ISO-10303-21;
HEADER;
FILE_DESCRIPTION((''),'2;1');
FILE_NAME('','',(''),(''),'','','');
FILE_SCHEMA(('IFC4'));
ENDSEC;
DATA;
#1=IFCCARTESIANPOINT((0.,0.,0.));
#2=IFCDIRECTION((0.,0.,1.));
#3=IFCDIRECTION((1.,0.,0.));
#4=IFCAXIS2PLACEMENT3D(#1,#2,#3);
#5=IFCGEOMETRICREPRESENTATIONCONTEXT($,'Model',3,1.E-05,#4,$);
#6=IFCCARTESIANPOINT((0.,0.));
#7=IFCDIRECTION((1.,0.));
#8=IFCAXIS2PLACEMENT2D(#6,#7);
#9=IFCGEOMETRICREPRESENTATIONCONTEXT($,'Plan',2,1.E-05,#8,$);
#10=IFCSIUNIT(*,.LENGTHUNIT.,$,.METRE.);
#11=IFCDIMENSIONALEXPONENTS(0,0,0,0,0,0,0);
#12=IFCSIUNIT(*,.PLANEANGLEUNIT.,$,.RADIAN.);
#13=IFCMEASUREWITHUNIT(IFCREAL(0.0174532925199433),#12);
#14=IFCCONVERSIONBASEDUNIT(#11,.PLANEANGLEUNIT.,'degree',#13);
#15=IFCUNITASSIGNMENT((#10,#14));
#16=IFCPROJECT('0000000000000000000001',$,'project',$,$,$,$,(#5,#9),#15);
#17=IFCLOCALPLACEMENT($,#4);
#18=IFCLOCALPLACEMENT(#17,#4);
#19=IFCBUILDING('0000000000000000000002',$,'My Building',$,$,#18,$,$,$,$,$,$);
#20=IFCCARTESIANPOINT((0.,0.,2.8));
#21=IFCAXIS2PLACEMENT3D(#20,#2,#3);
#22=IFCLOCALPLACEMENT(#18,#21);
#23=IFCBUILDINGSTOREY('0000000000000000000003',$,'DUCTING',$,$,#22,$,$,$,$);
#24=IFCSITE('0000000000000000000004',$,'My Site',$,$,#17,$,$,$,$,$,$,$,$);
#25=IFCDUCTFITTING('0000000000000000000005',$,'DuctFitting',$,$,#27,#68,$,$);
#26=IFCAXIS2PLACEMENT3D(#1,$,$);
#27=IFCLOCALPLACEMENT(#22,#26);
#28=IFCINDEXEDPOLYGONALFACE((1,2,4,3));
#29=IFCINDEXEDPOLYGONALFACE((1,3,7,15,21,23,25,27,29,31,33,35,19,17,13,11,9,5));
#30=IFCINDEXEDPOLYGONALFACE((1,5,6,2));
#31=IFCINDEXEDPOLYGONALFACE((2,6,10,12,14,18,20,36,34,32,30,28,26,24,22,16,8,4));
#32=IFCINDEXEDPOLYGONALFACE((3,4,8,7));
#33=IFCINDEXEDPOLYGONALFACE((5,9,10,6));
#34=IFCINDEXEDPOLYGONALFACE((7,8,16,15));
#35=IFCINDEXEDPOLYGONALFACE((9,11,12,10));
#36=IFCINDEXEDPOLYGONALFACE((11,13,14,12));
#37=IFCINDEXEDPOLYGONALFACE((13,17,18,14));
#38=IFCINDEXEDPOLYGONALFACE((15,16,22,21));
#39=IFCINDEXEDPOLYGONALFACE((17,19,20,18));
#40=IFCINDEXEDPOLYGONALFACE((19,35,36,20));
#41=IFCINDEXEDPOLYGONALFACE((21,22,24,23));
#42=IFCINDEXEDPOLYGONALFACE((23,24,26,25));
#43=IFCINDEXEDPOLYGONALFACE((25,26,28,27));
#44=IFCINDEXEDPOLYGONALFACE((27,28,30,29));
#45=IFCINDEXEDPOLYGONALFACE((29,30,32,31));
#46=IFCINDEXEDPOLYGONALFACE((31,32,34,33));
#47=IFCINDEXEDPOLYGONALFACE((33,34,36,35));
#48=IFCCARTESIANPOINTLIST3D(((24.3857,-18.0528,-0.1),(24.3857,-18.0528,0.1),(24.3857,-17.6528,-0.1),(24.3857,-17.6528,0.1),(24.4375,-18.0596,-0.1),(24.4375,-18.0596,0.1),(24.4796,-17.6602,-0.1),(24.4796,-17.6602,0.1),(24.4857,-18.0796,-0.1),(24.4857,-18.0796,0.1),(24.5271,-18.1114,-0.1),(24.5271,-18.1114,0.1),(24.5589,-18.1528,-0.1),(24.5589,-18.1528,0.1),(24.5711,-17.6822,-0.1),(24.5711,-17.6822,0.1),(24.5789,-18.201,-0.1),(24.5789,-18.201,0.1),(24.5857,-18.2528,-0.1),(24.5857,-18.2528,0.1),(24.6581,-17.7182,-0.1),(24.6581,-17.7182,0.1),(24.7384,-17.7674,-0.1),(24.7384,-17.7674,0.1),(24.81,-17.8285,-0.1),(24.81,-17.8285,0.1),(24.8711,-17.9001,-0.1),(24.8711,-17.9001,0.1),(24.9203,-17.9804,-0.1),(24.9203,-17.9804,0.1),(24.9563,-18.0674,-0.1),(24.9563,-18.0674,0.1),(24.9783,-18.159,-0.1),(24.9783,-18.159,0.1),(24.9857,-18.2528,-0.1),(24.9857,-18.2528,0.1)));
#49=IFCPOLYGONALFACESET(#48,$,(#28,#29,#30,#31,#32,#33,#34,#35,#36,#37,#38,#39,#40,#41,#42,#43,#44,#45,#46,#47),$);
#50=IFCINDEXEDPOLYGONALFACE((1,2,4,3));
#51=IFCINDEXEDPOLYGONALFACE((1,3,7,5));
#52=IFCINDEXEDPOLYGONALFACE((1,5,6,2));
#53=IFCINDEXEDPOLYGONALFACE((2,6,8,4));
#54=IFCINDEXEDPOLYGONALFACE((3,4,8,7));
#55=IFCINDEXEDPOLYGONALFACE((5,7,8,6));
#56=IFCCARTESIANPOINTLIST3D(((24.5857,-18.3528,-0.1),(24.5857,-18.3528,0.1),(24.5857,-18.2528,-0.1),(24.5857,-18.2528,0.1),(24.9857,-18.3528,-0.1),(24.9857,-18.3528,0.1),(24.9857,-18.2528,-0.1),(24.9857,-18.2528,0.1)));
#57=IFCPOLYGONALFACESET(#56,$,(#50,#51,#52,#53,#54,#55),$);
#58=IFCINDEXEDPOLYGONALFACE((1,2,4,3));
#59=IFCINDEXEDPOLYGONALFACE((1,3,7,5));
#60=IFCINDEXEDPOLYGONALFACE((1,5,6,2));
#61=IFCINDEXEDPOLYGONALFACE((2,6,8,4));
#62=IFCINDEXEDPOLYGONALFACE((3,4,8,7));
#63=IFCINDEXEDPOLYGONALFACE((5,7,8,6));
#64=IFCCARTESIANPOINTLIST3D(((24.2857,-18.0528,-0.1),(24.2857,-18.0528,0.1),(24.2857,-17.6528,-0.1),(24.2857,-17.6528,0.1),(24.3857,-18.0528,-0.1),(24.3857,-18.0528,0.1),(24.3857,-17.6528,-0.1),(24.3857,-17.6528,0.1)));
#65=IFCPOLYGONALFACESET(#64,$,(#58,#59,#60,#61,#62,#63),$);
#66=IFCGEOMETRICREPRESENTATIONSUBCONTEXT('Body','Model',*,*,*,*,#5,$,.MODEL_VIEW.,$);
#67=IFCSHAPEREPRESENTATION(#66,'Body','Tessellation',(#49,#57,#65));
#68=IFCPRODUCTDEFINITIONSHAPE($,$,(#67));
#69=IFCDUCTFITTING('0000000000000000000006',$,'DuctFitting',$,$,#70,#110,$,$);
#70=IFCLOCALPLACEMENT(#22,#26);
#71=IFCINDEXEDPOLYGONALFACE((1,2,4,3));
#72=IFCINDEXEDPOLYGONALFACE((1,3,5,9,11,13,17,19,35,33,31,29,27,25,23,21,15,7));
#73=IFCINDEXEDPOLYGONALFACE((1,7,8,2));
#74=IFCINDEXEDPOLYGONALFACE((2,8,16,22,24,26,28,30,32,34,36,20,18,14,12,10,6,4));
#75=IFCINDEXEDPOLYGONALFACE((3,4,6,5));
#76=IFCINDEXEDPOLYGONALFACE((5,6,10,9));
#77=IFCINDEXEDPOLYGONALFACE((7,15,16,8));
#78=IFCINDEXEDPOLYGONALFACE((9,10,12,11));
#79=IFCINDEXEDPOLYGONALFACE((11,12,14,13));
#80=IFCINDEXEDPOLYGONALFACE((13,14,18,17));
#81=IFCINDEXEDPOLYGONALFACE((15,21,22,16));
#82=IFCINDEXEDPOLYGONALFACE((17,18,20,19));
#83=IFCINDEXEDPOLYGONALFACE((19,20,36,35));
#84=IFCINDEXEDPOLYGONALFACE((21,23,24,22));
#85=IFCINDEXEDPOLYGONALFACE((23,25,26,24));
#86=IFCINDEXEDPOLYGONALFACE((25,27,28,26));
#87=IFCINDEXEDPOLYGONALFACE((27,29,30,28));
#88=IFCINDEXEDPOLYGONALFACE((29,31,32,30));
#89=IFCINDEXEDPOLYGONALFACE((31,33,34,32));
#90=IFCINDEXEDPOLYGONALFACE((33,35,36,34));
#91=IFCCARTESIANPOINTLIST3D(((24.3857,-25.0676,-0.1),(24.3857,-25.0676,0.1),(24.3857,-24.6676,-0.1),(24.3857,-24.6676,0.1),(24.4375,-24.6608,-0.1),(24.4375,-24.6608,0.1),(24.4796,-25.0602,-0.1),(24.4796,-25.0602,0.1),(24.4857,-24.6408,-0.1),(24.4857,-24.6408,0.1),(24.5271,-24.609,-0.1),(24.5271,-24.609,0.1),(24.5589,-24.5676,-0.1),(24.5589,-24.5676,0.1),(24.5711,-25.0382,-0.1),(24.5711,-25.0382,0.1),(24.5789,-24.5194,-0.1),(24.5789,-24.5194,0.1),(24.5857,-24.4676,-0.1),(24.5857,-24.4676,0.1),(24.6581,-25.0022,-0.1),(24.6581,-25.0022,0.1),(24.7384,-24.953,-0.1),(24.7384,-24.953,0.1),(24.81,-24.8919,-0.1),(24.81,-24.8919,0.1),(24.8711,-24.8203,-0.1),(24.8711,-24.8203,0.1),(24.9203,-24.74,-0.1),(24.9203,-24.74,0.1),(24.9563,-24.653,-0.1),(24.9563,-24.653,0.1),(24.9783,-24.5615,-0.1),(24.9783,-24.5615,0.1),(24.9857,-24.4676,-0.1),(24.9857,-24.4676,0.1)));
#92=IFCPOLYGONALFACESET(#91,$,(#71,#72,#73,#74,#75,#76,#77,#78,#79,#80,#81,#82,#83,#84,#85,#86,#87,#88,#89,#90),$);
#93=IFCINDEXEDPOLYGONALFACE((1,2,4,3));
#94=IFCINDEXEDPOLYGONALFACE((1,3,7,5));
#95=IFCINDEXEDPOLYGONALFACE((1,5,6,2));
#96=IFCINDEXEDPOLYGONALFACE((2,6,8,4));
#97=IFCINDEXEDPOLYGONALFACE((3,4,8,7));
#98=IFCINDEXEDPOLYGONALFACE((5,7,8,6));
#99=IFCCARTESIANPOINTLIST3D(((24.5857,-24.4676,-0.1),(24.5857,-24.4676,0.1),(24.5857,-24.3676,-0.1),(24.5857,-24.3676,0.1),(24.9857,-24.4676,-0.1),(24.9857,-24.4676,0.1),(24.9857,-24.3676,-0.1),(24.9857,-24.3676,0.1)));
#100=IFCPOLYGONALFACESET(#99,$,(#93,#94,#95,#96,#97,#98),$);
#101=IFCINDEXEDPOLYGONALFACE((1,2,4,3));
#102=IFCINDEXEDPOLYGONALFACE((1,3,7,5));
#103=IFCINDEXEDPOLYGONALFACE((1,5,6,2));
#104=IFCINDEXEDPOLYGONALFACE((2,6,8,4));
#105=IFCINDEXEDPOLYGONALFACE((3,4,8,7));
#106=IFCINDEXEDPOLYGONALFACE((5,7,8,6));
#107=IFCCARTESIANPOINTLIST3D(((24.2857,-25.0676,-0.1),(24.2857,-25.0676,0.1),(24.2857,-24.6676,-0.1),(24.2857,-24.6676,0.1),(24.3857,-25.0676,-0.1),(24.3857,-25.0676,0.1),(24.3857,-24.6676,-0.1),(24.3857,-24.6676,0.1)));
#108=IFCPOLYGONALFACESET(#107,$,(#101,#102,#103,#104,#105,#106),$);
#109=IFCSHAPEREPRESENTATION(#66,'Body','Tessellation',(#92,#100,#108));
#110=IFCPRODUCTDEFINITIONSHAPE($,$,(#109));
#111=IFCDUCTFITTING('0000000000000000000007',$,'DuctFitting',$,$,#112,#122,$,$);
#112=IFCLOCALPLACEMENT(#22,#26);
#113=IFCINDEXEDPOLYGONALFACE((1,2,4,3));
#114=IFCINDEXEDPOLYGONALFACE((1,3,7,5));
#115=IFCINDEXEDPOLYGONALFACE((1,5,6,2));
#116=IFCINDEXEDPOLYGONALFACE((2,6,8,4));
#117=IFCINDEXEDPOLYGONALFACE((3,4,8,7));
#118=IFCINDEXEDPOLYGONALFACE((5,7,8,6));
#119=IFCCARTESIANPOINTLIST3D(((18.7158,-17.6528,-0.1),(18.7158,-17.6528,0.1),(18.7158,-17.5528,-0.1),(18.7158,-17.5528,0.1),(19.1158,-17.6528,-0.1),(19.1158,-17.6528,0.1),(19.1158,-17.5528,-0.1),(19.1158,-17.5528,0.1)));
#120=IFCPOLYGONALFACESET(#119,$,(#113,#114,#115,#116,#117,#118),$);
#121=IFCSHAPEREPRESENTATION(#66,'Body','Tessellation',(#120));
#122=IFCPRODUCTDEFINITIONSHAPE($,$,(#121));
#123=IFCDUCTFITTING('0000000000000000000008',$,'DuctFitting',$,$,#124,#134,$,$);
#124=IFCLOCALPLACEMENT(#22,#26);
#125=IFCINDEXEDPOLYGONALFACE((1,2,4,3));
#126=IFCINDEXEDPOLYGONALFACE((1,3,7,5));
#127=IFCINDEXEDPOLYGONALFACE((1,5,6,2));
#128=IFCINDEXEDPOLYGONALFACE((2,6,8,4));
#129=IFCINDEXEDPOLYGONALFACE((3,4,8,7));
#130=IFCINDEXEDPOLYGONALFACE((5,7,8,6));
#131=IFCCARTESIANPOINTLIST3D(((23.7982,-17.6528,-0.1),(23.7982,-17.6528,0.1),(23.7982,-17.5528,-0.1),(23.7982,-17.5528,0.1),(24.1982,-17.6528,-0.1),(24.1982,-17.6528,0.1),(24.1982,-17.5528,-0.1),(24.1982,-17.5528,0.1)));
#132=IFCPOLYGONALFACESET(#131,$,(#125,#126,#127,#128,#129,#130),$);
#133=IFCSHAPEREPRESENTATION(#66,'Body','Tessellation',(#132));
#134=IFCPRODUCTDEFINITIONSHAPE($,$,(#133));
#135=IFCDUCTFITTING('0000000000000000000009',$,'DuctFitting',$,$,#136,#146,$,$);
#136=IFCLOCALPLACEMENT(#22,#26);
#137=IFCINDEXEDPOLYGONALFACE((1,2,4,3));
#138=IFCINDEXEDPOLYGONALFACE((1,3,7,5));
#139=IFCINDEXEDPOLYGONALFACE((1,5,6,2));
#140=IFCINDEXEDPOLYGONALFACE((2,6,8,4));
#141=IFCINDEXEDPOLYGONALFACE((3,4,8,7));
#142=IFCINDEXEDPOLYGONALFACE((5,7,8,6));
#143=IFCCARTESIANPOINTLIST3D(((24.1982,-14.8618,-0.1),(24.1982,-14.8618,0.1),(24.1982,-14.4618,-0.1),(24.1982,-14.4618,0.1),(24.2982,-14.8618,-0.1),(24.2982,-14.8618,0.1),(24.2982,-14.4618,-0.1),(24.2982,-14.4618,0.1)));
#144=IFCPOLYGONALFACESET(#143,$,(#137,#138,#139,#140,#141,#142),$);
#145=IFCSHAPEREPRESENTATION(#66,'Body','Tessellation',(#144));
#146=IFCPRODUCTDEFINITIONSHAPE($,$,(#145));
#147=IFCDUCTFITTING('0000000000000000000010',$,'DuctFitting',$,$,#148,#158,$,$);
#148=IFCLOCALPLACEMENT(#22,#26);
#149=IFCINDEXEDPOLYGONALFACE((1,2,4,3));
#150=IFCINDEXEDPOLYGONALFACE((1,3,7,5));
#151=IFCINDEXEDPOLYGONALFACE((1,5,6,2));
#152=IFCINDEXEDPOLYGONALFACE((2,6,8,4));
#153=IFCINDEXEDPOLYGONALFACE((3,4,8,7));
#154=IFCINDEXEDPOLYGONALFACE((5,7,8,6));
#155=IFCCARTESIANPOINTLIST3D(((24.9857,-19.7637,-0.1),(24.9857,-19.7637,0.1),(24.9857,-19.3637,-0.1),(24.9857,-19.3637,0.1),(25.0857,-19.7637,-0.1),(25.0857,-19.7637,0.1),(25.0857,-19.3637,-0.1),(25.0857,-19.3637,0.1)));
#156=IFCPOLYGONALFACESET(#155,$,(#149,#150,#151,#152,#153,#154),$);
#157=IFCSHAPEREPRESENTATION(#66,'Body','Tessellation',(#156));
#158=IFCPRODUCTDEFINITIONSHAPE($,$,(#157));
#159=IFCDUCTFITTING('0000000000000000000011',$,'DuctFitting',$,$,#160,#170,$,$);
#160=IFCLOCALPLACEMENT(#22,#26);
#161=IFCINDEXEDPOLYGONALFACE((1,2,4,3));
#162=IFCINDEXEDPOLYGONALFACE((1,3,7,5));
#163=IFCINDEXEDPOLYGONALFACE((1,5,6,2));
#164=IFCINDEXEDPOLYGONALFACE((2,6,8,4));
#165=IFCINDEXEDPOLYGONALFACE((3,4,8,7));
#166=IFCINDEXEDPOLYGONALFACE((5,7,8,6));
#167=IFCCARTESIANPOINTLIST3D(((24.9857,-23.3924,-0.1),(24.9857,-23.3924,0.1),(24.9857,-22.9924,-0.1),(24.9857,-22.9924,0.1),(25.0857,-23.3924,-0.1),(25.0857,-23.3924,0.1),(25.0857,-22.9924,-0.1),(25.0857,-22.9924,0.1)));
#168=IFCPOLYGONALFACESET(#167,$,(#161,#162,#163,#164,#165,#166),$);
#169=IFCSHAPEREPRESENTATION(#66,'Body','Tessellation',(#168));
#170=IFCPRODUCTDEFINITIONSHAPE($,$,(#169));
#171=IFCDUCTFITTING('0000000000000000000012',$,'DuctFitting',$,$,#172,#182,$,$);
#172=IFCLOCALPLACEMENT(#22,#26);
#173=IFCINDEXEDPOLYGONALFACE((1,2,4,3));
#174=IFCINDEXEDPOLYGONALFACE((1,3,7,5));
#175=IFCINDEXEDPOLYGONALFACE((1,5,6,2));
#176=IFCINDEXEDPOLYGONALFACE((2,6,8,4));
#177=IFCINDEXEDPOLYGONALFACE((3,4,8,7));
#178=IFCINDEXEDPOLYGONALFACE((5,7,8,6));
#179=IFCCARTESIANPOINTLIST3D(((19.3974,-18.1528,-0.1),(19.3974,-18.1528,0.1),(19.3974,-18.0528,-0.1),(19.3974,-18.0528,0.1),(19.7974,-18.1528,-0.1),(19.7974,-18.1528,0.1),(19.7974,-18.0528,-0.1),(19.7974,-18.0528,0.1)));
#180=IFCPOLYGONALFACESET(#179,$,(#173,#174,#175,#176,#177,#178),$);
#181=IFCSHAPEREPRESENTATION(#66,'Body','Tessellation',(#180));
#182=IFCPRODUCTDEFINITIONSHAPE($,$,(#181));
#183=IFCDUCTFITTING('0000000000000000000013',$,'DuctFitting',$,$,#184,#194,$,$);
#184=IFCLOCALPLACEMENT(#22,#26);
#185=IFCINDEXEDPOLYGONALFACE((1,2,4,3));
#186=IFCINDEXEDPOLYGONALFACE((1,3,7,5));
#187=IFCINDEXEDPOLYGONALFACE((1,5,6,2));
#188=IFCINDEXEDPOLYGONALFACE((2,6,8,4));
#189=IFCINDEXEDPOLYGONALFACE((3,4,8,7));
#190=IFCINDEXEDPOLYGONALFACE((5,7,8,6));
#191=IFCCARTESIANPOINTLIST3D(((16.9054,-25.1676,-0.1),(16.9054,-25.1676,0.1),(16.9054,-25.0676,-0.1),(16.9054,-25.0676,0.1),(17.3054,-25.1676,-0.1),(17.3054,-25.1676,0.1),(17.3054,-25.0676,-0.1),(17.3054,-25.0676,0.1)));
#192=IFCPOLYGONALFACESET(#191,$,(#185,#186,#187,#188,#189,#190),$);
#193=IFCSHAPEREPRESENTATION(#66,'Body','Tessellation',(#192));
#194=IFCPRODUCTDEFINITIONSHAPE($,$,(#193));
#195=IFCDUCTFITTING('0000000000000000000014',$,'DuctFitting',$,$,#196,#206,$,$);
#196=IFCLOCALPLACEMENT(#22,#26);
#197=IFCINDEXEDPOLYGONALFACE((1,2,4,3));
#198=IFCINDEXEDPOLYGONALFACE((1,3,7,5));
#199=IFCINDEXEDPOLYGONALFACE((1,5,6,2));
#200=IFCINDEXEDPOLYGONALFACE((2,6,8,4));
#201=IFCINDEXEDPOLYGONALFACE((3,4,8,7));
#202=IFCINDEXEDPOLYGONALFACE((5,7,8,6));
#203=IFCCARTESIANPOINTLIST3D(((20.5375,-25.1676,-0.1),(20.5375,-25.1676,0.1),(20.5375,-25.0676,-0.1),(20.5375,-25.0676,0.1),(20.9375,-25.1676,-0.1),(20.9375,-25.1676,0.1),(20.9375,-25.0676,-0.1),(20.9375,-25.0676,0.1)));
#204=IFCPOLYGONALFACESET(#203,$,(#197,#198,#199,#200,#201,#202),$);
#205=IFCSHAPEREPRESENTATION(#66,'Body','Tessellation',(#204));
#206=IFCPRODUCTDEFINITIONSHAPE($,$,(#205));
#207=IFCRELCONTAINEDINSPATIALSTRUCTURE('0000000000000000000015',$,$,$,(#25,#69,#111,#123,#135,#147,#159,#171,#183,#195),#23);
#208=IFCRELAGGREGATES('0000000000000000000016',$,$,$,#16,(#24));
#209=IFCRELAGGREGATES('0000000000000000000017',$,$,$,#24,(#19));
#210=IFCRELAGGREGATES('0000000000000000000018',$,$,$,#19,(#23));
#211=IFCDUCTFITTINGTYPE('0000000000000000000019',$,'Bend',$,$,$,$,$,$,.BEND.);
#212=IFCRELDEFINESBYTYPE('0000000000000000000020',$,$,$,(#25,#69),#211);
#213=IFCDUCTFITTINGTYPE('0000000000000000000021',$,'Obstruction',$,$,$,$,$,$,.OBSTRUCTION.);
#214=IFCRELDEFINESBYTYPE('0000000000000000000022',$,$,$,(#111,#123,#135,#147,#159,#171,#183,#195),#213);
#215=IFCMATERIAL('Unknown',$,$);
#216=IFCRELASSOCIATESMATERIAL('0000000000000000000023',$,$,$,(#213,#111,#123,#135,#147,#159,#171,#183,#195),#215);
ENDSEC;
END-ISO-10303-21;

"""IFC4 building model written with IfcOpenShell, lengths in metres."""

from ifc_helpers import new_model, entity, si_unit, converted_unit, frame, origin_with_axes, origin_2d_with_axis, place, context, subcontext, project, spatial, line, arc, indexed_curve, rectangle, outline, extrude, source, transform, mapped, material, material_profile, profile_set, profile_usage, type_object, type_shapes, element, save


model = new_model("IFC4")

# Units and contexts
model_context = context("Model", 3, precision=1e-05, world=origin_with_axes())
plan_context = context("Plan", 2, precision=1e-05, world=origin_2d_with_axis())
body_context = subcontext(model_context, "Body", "Model", "MODEL_VIEW")
ifc_project = project(units=[si_unit("LENGTHUNIT", "METRE"), converted_unit("PLANEANGLEUNIT", "degree", entity("IfcReal", 0.0174532925199433), si_unit("PLANEANGLEUNIT", "RADIAN"), dimensions=[0, 0, 0, 0, 0, 0, 0])], contexts=[model_context, plan_context])

# Site, building, storey
site_placement = place(None, origin_with_axes())
site = spatial("IfcSite", under=ifc_project, at=site_placement, Name="My Site")
building_placement = place(site_placement, origin_with_axes())
building = spatial("IfcBuilding", under=site, at=building_placement, Name="My Building")
storey_placement = place(building_placement, frame((0.0, 0.0, 2.8), z_axis=(0.0, 0.0, 1.0), x_axis=(1.0, 0.0, 0.0)))
storey = spatial("IfcBuildingStorey", under=building, at=storey_placement, Name="DUCTING")

# Shared definitions
ifc_material = material(Name="Unknown")

# Duct fittings
duct_fitting_type_1 = type_object("IfcDuctFittingType", Name="Bend", PredefinedType="BEND")
shared_shape = source(origin_with_axes(), body_context, "Body", "SweptSolid", [
    extrude(outline(indexed_curve([(-0.2, 0.0), (-0.2586, -0.1414), (-0.4, -0.2), (-0.4, -0.6), (0.0243, -0.4243), (0.2, 0.0)], segments=[arc(1, 2, 3), line(3, 4), arc(4, 5, 6), line(6, 1)])), frame((0.0, -0.1, -0.1), z_axis=(0.0, -1.0, 0.0), x_axis=(1.0, 0.0, 0.0)), (0.0, 0.0, -1.0), 0.2),
    extrude(rectangle(XDim=0.4, YDim=0.2), origin_with_axes(), (0.0, 0.0, -1.0), 0.1),
    extrude(rectangle(XDim=0.4, YDim=0.2), frame((-0.4, 0.0, -0.5), z_axis=(-1.0, 0.0, -0.000001), x_axis=(0.000001, 0.0, -1.0)), (0.0, 0.0, 1.0), 0.1),
])
type_shapes(duct_fitting_type_1, [shared_shape])
for number, where, z_axis, x_axis, name in (
    (1, (24.7857, -18.3528, 0.0), (0.0, -1.0, 0.0), (1.0, 0.0, 0.0), "DuctFitting"),
    (2, (24.7857, -24.3676, 0.0), (0.0, 1.0, 0.0), (1.0, 0.0, 0.0), "DuctFitting"),
):
    element("IfcDuctFitting", number, at=place(storey_placement, frame(where, z_axis=z_axis, x_axis=x_axis)), inside=storey, type_object=duct_fitting_type_1, Name=name, context=body_context, shape_type="MappedRepresentation", body=[
        mapped(shared_shape, transform((0.0, 0.0, 0.0), x_axis=(1.0, 0.0, 0.0), y_axis=(0.0, 1.0, 0.0), z_axis=(0.0, 0.0, 1.0), scale=1.0)),
    ])
ifc_material_profile_1 = material_profile(ifc_material, rectangle(XDim=0.4, YDim=0.2))
ifc_profile_set_1 = profile_set([ifc_material_profile_1])
ifc_profile_usage_1 = profile_usage(ifc_profile_set_1, cardinal=5)
duct_fitting_type_2 = type_object("IfcDuctFittingType", Name="Obstruction", PredefinedType="OBSTRUCTION", material=ifc_profile_set_1)
duct_fitting_1_placement = place(storey_placement, frame((18.9158, -17.6528, 0.0), z_axis=(0.0, 1.0, 0.0), x_axis=(-1.0, 0.0, 0.0)))
element("IfcDuctFitting", 3, at=duct_fitting_1_placement, inside=storey, type_object=duct_fitting_type_2, material=ifc_profile_usage_1, Name="DuctFitting", context=body_context, shape_type="SweptSolid", body=[
    extrude(rectangle(XDim=0.4, YDim=0.2), origin_with_axes(), (0.0, 0.0, 1.0), 0.1),
])
ifc_profile_usage_2 = profile_usage(ifc_profile_set_1, cardinal=5)
duct_fitting_2_placement = place(storey_placement, frame((23.9982, -17.6528, 0.0), z_axis=(0.0, 1.0, 0.0), x_axis=(-1.0, 0.0, 0.0)))
element("IfcDuctFitting", 4, at=duct_fitting_2_placement, inside=storey, type_object=duct_fitting_type_2, material=ifc_profile_usage_2, Name="DuctFitting", context=body_context, shape_type="SweptSolid", body=[
    extrude(rectangle(XDim=0.4, YDim=0.2), origin_with_axes(), (0.0, 0.0, 1.0), 0.1),
])
ifc_profile_usage_3 = profile_usage(ifc_profile_set_1, cardinal=5)
duct_fitting_3_placement = place(storey_placement, frame((24.1982, -14.6618, 0.0), z_axis=(1.0, 0.0, 0.0), x_axis=(0.0, 1.0, 0.0)))
element("IfcDuctFitting", 5, at=duct_fitting_3_placement, inside=storey, type_object=duct_fitting_type_2, material=ifc_profile_usage_3, Name="DuctFitting", context=body_context, shape_type="SweptSolid", body=[
    extrude(rectangle(XDim=0.4, YDim=0.2), origin_with_axes(), (0.0, 0.0, 1.0), 0.1),
])
ifc_profile_usage_4 = profile_usage(ifc_profile_set_1, cardinal=5)
duct_fitting_4_placement = place(storey_placement, frame((24.9857, -19.5637, 0.0), z_axis=(1.0, 0.0, 0.0), x_axis=(0.0, 1.0, 0.0)))
element("IfcDuctFitting", 6, at=duct_fitting_4_placement, inside=storey, type_object=duct_fitting_type_2, material=ifc_profile_usage_4, Name="DuctFitting", context=body_context, shape_type="SweptSolid", body=[
    extrude(rectangle(XDim=0.4, YDim=0.2), origin_with_axes(), (0.0, 0.0, 1.0), 0.1),
])
ifc_profile_usage_5 = profile_usage(ifc_profile_set_1, cardinal=5)
duct_fitting_5_placement = place(storey_placement, frame((24.9857, -23.1924, 0.0), z_axis=(1.0, 0.0, 0.0), x_axis=(0.0, 1.0, 0.0)))
element("IfcDuctFitting", 7, at=duct_fitting_5_placement, inside=storey, type_object=duct_fitting_type_2, material=ifc_profile_usage_5, Name="DuctFitting", context=body_context, shape_type="SweptSolid", body=[
    extrude(rectangle(XDim=0.4, YDim=0.2), origin_with_axes(), (0.0, 0.0, 1.0), 0.1),
])
ifc_profile_usage_6 = profile_usage(ifc_profile_set_1, cardinal=5)
duct_fitting_6_placement = place(storey_placement, frame((19.5974, -18.0528, 0.0), z_axis=(0.0, -1.0, 0.0), x_axis=(1.0, 0.0, 0.0)))
element("IfcDuctFitting", 8, at=duct_fitting_6_placement, inside=storey, type_object=duct_fitting_type_2, material=ifc_profile_usage_6, Name="DuctFitting", context=body_context, shape_type="SweptSolid", body=[
    extrude(rectangle(XDim=0.4, YDim=0.2), origin_with_axes(), (0.0, 0.0, 1.0), 0.1),
])
ifc_profile_usage_7 = profile_usage(ifc_profile_set_1, cardinal=5)
duct_fitting_7_placement = place(storey_placement, frame((17.1054, -25.0676, 0.0), z_axis=(0.0, -1.0, 0.0), x_axis=(1.0, 0.0, 0.0)))
element("IfcDuctFitting", 9, at=duct_fitting_7_placement, inside=storey, type_object=duct_fitting_type_2, material=ifc_profile_usage_7, Name="DuctFitting", context=body_context, shape_type="SweptSolid", body=[
    extrude(rectangle(XDim=0.4, YDim=0.2), origin_with_axes(), (0.0, 0.0, 1.0), 0.1),
])
ifc_profile_usage_8 = profile_usage(ifc_profile_set_1, cardinal=5)
duct_fitting_8_placement = place(storey_placement, frame((20.7375, -25.0676, 0.0), z_axis=(0.0, -1.0, 0.0), x_axis=(1.0, 0.0, 0.0)))
element("IfcDuctFitting", 10, at=duct_fitting_8_placement, inside=storey, type_object=duct_fitting_type_2, material=ifc_profile_usage_8, Name="DuctFitting", context=body_context, shape_type="SweptSolid", body=[
    extrude(rectangle(XDim=0.4, YDim=0.2), origin_with_axes(), (0.0, 0.0, 1.0), 0.1),
])

save(model, "model.ifc")
